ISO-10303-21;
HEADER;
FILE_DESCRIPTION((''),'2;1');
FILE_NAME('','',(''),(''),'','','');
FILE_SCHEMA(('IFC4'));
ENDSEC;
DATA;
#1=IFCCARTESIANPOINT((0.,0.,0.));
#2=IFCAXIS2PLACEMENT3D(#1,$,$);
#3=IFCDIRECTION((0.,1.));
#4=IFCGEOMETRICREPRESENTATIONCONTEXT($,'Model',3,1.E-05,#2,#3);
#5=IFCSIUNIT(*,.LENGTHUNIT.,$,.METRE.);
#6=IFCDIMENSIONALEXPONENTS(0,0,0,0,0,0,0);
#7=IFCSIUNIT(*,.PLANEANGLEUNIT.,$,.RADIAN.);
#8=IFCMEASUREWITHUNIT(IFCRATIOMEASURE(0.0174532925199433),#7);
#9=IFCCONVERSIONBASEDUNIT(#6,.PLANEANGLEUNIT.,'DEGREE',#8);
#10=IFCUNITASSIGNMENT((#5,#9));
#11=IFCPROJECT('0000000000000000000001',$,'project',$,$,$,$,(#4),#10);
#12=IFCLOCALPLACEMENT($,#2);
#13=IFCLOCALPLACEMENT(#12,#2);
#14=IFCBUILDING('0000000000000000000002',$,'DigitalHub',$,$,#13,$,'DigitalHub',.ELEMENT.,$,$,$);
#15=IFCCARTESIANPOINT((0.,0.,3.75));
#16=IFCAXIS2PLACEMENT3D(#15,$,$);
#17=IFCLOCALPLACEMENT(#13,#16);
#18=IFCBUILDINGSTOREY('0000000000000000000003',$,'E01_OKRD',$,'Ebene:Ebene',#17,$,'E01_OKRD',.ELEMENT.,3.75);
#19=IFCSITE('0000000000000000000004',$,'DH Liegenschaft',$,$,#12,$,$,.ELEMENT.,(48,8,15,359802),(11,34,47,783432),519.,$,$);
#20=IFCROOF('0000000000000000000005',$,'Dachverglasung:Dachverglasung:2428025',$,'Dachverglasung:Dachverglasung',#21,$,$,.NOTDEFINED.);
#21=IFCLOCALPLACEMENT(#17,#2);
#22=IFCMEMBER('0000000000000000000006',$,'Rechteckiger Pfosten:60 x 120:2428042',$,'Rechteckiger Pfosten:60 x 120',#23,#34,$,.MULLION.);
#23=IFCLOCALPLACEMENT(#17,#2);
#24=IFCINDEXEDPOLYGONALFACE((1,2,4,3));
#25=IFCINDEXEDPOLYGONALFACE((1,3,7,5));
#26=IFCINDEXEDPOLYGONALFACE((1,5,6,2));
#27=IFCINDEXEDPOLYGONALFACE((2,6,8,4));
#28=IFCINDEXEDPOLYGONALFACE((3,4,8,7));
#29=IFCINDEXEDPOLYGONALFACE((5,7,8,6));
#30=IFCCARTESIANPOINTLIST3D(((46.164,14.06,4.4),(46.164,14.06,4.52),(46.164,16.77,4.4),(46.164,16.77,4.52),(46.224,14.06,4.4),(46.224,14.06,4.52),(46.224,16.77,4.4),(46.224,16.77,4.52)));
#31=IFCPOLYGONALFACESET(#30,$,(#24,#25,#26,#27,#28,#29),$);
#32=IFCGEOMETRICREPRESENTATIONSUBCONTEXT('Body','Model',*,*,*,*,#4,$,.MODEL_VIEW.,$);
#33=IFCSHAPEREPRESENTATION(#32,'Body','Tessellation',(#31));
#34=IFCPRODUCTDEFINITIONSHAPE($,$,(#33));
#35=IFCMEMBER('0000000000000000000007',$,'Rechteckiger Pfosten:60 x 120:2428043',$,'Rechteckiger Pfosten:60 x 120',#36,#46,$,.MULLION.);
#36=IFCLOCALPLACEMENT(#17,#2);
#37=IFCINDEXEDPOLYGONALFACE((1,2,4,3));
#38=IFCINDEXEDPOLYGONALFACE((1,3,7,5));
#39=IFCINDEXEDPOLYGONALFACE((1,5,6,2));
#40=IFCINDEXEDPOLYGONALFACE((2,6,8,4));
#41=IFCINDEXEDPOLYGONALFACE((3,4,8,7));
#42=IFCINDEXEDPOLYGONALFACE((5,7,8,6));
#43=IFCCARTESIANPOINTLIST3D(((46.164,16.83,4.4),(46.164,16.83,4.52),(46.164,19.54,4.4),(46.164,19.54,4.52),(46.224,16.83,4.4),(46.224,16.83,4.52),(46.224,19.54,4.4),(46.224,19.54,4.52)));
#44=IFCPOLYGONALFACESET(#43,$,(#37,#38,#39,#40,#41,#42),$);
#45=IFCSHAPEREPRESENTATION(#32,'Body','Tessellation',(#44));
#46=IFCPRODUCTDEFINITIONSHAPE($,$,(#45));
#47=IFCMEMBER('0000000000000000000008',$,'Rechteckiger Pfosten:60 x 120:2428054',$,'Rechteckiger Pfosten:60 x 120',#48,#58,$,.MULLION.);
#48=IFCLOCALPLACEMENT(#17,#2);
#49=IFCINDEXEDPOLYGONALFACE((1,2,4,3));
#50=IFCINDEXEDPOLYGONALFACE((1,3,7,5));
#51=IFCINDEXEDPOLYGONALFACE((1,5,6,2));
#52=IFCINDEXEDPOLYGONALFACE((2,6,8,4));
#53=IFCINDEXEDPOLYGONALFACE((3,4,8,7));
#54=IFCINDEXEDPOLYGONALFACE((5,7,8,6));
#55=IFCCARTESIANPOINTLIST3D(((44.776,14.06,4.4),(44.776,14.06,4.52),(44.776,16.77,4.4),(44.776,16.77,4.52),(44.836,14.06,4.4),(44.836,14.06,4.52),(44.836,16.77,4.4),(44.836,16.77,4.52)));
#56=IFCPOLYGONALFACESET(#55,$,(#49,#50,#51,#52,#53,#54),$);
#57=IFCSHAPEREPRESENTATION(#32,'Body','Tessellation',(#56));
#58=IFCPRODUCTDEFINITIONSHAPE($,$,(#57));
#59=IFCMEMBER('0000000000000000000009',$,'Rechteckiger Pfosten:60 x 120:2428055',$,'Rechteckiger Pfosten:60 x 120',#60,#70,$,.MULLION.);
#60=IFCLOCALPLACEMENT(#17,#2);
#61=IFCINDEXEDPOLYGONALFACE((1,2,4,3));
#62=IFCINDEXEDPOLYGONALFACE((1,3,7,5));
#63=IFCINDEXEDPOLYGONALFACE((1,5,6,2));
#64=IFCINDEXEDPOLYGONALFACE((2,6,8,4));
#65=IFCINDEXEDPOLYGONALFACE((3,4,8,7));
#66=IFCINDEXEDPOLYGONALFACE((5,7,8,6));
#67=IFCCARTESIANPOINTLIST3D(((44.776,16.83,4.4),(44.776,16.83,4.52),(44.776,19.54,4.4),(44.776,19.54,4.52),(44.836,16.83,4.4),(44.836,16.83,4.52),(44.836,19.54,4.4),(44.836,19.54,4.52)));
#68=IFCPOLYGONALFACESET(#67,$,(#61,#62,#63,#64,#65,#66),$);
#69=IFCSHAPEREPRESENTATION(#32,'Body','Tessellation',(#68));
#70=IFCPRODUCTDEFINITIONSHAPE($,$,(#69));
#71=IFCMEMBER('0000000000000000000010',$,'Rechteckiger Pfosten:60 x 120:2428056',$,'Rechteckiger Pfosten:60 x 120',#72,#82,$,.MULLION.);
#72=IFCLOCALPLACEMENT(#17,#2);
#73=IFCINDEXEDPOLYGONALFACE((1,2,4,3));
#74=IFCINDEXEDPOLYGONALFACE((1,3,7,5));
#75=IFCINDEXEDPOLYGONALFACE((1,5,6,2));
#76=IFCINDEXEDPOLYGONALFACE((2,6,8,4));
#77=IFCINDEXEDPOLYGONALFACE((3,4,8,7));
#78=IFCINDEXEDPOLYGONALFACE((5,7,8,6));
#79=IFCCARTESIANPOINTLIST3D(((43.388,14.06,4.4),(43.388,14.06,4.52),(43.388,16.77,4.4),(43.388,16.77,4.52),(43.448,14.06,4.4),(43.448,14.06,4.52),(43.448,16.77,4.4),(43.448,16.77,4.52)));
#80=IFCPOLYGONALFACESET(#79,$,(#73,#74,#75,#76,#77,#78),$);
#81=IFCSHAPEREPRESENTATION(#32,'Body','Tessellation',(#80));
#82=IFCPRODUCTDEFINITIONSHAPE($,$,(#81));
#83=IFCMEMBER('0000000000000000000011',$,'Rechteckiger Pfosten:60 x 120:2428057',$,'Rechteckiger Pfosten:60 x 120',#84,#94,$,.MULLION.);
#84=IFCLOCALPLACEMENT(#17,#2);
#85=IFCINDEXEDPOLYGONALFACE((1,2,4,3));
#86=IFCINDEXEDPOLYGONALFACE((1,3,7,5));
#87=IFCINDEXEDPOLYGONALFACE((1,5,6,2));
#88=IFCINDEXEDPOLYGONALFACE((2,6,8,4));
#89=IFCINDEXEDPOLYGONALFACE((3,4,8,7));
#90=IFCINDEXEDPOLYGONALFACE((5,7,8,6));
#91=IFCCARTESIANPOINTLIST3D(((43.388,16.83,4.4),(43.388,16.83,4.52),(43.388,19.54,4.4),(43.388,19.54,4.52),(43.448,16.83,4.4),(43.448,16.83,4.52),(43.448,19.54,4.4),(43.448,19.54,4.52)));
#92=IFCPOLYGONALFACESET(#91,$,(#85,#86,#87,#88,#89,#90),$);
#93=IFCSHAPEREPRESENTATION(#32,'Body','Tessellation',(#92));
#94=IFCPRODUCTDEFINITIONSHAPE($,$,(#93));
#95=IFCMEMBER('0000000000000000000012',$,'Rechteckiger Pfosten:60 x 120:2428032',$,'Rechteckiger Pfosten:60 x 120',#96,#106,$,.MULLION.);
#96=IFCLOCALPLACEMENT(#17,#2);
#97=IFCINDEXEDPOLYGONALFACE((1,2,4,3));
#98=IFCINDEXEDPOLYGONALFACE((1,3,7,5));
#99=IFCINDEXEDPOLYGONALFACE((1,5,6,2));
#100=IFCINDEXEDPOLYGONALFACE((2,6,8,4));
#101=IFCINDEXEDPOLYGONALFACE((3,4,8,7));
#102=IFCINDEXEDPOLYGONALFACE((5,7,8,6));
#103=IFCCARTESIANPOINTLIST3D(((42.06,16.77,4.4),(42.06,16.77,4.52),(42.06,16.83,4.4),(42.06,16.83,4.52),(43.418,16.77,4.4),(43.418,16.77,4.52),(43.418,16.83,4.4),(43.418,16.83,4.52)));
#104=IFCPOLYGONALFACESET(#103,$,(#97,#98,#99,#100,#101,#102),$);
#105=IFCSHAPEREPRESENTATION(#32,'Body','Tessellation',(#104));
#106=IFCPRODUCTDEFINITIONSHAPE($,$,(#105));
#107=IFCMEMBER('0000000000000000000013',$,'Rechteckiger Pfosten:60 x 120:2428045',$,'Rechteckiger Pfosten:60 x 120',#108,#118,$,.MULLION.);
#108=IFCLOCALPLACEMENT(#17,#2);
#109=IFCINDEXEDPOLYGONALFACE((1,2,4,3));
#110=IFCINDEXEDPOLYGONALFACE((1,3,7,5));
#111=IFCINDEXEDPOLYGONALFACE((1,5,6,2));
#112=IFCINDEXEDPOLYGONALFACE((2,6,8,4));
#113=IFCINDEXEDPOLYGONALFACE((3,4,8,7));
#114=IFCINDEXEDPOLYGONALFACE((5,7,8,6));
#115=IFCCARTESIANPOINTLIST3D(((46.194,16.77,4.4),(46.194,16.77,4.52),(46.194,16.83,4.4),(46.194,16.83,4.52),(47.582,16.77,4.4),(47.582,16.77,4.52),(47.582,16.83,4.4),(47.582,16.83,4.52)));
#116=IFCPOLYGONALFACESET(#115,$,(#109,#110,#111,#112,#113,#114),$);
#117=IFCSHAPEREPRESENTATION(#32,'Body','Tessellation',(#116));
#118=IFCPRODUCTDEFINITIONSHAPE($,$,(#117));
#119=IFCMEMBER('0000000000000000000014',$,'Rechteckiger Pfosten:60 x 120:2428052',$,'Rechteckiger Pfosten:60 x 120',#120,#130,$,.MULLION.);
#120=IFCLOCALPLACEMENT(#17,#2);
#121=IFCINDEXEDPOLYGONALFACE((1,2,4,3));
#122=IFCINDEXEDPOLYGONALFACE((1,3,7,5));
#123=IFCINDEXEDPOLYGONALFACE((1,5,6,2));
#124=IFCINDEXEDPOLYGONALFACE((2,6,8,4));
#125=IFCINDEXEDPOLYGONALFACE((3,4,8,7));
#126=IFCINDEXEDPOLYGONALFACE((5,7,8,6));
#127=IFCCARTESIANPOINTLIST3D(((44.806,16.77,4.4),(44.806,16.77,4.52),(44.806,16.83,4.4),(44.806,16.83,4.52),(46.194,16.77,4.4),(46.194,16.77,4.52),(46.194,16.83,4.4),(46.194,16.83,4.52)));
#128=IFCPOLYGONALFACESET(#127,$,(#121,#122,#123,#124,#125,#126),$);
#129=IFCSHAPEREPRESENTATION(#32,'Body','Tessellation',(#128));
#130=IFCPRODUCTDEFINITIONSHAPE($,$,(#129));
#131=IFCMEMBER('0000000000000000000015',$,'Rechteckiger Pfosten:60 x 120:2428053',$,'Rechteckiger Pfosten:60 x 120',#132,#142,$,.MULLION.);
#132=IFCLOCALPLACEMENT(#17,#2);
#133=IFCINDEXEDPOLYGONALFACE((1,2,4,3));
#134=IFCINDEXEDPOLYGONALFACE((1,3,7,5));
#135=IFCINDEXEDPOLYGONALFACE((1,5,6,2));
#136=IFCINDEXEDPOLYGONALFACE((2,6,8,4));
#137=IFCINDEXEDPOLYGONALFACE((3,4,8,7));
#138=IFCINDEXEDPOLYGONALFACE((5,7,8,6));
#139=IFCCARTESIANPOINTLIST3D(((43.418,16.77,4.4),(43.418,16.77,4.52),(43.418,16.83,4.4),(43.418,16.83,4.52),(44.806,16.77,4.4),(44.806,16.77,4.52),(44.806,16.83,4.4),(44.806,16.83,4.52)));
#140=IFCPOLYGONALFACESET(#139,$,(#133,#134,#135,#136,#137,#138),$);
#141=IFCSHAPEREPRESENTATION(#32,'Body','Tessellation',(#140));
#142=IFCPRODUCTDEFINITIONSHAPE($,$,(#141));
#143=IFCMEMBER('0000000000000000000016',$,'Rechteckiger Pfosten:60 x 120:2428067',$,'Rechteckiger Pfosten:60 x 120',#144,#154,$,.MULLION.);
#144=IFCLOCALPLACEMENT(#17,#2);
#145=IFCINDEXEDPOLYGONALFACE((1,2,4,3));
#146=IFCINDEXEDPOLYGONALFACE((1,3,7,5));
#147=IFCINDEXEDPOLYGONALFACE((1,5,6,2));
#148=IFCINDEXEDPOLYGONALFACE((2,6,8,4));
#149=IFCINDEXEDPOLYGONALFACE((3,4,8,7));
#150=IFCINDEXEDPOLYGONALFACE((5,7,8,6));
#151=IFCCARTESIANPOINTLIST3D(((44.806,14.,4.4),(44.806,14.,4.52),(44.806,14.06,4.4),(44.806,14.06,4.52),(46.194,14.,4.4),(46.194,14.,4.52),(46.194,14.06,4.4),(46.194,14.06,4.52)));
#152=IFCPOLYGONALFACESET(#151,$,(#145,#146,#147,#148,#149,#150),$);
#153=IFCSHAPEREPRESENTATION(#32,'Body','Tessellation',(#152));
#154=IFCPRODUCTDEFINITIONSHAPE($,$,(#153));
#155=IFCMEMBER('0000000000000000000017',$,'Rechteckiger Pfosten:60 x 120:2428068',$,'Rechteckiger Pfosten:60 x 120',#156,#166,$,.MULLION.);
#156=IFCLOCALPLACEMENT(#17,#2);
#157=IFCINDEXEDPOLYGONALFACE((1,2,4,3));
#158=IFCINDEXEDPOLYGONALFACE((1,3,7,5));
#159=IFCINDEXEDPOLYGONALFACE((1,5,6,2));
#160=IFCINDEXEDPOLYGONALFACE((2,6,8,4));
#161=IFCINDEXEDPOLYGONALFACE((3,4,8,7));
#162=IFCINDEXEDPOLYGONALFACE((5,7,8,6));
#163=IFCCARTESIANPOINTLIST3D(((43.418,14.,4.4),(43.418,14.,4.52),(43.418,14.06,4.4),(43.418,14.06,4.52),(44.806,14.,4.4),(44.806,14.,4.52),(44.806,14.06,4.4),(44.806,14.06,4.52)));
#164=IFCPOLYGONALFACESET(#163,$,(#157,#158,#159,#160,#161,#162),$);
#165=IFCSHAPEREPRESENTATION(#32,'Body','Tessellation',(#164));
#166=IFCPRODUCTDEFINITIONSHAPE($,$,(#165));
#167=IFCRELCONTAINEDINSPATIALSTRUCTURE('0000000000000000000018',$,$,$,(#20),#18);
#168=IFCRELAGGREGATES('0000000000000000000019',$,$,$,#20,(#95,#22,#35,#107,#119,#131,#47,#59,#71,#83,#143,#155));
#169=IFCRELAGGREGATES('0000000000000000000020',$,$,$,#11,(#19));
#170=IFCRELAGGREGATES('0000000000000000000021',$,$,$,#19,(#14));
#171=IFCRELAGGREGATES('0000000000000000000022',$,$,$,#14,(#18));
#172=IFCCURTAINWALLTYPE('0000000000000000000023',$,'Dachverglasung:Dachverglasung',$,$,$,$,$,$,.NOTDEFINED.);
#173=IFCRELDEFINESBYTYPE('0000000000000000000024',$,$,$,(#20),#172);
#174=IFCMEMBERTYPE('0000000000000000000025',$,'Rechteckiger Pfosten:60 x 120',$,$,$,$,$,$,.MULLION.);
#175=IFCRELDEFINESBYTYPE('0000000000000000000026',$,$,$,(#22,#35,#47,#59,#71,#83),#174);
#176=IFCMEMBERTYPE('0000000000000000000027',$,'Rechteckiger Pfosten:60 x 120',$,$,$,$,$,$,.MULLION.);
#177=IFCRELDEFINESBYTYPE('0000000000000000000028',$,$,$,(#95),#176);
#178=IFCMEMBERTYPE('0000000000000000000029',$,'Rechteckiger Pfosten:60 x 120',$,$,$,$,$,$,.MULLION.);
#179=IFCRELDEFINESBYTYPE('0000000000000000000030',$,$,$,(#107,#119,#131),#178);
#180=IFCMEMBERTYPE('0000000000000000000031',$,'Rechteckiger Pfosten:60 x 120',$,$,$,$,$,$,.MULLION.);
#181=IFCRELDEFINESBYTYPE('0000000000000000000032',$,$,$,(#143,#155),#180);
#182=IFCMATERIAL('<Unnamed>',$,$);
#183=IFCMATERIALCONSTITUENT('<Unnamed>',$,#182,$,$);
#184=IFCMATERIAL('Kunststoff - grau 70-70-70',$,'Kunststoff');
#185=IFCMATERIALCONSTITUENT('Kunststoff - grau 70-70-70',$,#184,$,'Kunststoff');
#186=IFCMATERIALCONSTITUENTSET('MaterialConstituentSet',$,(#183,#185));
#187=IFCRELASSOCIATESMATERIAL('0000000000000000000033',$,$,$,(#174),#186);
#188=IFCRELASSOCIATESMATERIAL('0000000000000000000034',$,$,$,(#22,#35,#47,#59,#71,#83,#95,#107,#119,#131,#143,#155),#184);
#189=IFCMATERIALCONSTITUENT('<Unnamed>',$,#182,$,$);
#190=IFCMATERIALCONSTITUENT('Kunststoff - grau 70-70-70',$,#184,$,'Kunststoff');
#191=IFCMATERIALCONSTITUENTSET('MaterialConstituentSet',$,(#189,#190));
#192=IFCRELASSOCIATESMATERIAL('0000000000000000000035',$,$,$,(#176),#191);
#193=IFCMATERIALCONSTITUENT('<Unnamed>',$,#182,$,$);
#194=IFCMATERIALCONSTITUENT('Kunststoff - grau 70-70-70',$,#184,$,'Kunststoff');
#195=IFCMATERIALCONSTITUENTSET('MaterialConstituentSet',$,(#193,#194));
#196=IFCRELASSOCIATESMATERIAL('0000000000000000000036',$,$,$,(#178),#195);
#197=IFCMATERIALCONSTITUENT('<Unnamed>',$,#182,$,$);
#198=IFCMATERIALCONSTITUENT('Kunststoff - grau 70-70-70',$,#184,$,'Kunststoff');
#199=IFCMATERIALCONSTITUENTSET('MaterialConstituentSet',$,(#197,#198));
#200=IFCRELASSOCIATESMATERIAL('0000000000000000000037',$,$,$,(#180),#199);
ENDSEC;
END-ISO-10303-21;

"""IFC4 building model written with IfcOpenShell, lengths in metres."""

from ifc_helpers import new_model, entity, si_unit, converted_unit, direction, frame, origin, place, context, subcontext, project, spatial, indexed_curve, outline, extrude, source, transform, mapped, material, constituent, constituent_set, type_object, type_shapes, element, aggregate, save


model = new_model("IFC4")

# Units and contexts
model_context = context("Model", 3, precision=1e-05, world=origin(), true_north=direction((0.0, 1.0)))
body_context = subcontext(model_context, "Body", "Model", "MODEL_VIEW")
ifc_project = project(units=[si_unit("LENGTHUNIT", "METRE"), converted_unit("PLANEANGLEUNIT", "DEGREE", entity("IfcRatioMeasure", 0.0174532925199433), si_unit("PLANEANGLEUNIT", "RADIAN"), dimensions=[0, 0, 0, 0, 0, 0, 0])], contexts=[model_context])

# Site, building, storey
site_placement = place(None, frame((0.0, 0.0, 0.0)))
site = spatial("IfcSite", under=ifc_project, at=site_placement, Name="DH Liegenschaft", CompositionType="ELEMENT", RefLatitude=(48, 8, 15, 359802), RefLongitude=(11, 34, 47, 783432), RefElevation=519.0)
building_placement = place(site_placement, origin())
building = spatial("IfcBuilding", under=site, at=building_placement, Name="DigitalHub", LongName="DigitalHub", CompositionType="ELEMENT")
storey_placement = place(building_placement, frame((0.0, 0.0, 3.75)))
storey = spatial("IfcBuildingStorey", under=building, at=storey_placement, Name="E01_OKRD", ObjectType="Ebene:Ebene", LongName="E01_OKRD", CompositionType="ELEMENT", Elevation=3.75)

# Roof, members
curtain_wall_type = type_object("IfcCurtainWallType", Name="Dachverglasung:Dachverglasung", PredefinedType="NOTDEFINED")
roof_placement = place(storey_placement, frame((0.0, 0.0, -3.75)))
roof = element("IfcRoof", 1, at=roof_placement, inside=storey, type_object=curtain_wall_type, Name="Dachverglasung:Dachverglasung:2428025", ObjectType="Dachverglasung:Dachverglasung", PredefinedType="NOTDEFINED")
ifc_material_1 = material(Name="Kunststoff - grau 70-70-70", Category="Kunststoff")
ifc_material_2 = material(Name="<Unnamed>")
ifc_constituent_1 = constituent(ifc_material_2, Name="<Unnamed>")
ifc_constituent_2 = constituent(ifc_material_1, Name="Kunststoff - grau 70-70-70", Category="Kunststoff")
ifc_constituent_set_1 = constituent_set(constituents=[ifc_constituent_1, ifc_constituent_2], Name="MaterialConstituentSet")
member_type_1 = type_object("IfcMemberType", Name="Rechteckiger Pfosten:60 x 120", PredefinedType="MULLION", material=ifc_constituent_set_1)
shared_shape_1 = source(origin(), body_context, "Body", "SweptSolid", [
    extrude(outline(indexed_curve([(-0.06, -0.03), (0.06, -0.03), (0.06, 0.03), (-0.06, 0.03), (-0.06, -0.03)], self_intersect=False)), frame((0.0, 0.0, -2.71), z_axis=(0.0, 0.0, 1.0), x_axis=(0.0, -1.0, 0.0)), (0.0, 0.0, 1.0), 2.71),
])
type_shapes(member_type_1, [shared_shape_1])
member_1_placement = place(storey_placement, frame((46.194, 14.06, 4.46), z_axis=(0.0, -1.0, 0.0), x_axis=(-1.0, 0.0, 0.0)))
member_1 = element("IfcMember", 2, at=member_1_placement, type_object=member_type_1, material=ifc_material_1, Name="Rechteckiger Pfosten:60 x 120:2428042", ObjectType="Rechteckiger Pfosten:60 x 120", PredefinedType="MULLION", context=body_context, shape_type="MappedRepresentation", body=[
    mapped(shared_shape_1, transform((0.0, 0.0, 0.0), scale=1.0)),
])
member_2_placement = place(storey_placement, frame((46.194, 16.83, 4.46), z_axis=(0.0, -1.0, 0.0), x_axis=(-1.0, 0.0, 0.0)))
member_2 = element("IfcMember", 3, at=member_2_placement, type_object=member_type_1, material=ifc_material_1, Name="Rechteckiger Pfosten:60 x 120:2428043", ObjectType="Rechteckiger Pfosten:60 x 120", PredefinedType="MULLION", context=body_context, shape_type="MappedRepresentation", body=[
    mapped(shared_shape_1, transform((0.0, 0.0, 0.0), scale=1.0)),
])
member_3_placement = place(storey_placement, frame((44.806, 14.06, 4.46), z_axis=(0.0, -1.0, 0.0), x_axis=(-1.0, 0.0, 0.0)))
member_3 = element("IfcMember", 4, at=member_3_placement, type_object=member_type_1, material=ifc_material_1, Name="Rechteckiger Pfosten:60 x 120:2428054", ObjectType="Rechteckiger Pfosten:60 x 120", PredefinedType="MULLION", context=body_context, shape_type="MappedRepresentation", body=[
    mapped(shared_shape_1, transform((0.0, 0.0, 0.0), scale=1.0)),
])
member_4_placement = place(storey_placement, frame((44.806, 16.83, 4.46), z_axis=(0.0, -1.0, 0.0), x_axis=(-1.0, 0.0, 0.0)))
member_4 = element("IfcMember", 5, at=member_4_placement, type_object=member_type_1, material=ifc_material_1, Name="Rechteckiger Pfosten:60 x 120:2428055", ObjectType="Rechteckiger Pfosten:60 x 120", PredefinedType="MULLION", context=body_context, shape_type="MappedRepresentation", body=[
    mapped(shared_shape_1, transform((0.0, 0.0, 0.0), scale=1.0)),
])
member_5_placement = place(storey_placement, frame((43.418, 14.06, 4.46), z_axis=(0.0, -1.0, 0.0), x_axis=(-1.0, 0.0, 0.0)))
member_5 = element("IfcMember", 6, at=member_5_placement, type_object=member_type_1, material=ifc_material_1, Name="Rechteckiger Pfosten:60 x 120:2428056", ObjectType="Rechteckiger Pfosten:60 x 120", PredefinedType="MULLION", context=body_context, shape_type="MappedRepresentation", body=[
    mapped(shared_shape_1, transform((0.0, 0.0, 0.0), scale=1.0)),
])
member_6_placement = place(storey_placement, frame((43.418, 16.83, 4.46), z_axis=(0.0, -1.0, 0.0), x_axis=(-1.0, 0.0, 0.0)))
member_6 = element("IfcMember", 7, at=member_6_placement, type_object=member_type_1, material=ifc_material_1, Name="Rechteckiger Pfosten:60 x 120:2428057", ObjectType="Rechteckiger Pfosten:60 x 120", PredefinedType="MULLION", context=body_context, shape_type="MappedRepresentation", body=[
    mapped(shared_shape_1, transform((0.0, 0.0, 0.0), scale=1.0)),
])
ifc_constituent_3 = constituent(ifc_material_2, Name="<Unnamed>")
ifc_constituent_4 = constituent(ifc_material_1, Name="Kunststoff - grau 70-70-70", Category="Kunststoff")
ifc_constituent_set_2 = constituent_set(constituents=[ifc_constituent_3, ifc_constituent_4], Name="MaterialConstituentSet")
member_type_2 = type_object("IfcMemberType", Name="Rechteckiger Pfosten:60 x 120", PredefinedType="MULLION", material=ifc_constituent_set_2)
shared_shape_2 = source(origin(), body_context, "Body", "SweptSolid", [
    extrude(outline(indexed_curve([(-0.06, -0.03), (0.06, -0.03), (0.06, 0.03), (-0.06, 0.03), (-0.06, -0.03)], self_intersect=False)), frame((0.0, 0.0, -1.358), z_axis=(0.0, 0.0, 1.0), x_axis=(0.0, -1.0, 0.0)), (0.0, 0.0, 1.0), 1.358),
])
type_shapes(member_type_2, [shared_shape_2])
member_7_placement = place(storey_placement, frame((42.06, 16.8, 4.46), z_axis=(-1.0, 0.0, 0.0), x_axis=(0.0, 1.0, 0.0)))
member_7 = element("IfcMember", 8, at=member_7_placement, type_object=member_type_2, material=ifc_material_1, Name="Rechteckiger Pfosten:60 x 120:2428032", ObjectType="Rechteckiger Pfosten:60 x 120", PredefinedType="MULLION", context=body_context, shape_type="MappedRepresentation", body=[
    mapped(shared_shape_2, transform((0.0, 0.0, 0.0), scale=1.0)),
])
ifc_constituent_5 = constituent(ifc_material_2, Name="<Unnamed>")
ifc_constituent_6 = constituent(ifc_material_1, Name="Kunststoff - grau 70-70-70", Category="Kunststoff")
ifc_constituent_set_3 = constituent_set(constituents=[ifc_constituent_5, ifc_constituent_6], Name="MaterialConstituentSet")
member_type_3 = type_object("IfcMemberType", Name="Rechteckiger Pfosten:60 x 120", PredefinedType="MULLION", material=ifc_constituent_set_3)
shared_shape_3 = source(origin(), body_context, "Body", "SweptSolid", [
    extrude(outline(indexed_curve([(-0.06, -0.03), (0.06, -0.03), (0.06, 0.03), (-0.06, 0.03), (-0.06, -0.03)], self_intersect=False)), frame((0.0, 0.0, -1.388), z_axis=(0.0, 0.0, 1.0), x_axis=(0.0, -1.0, 0.0)), (0.0, 0.0, 1.0), 1.388),
])
type_shapes(member_type_3, [shared_shape_3])
member_8_placement = place(storey_placement, frame((46.194, 16.8, 4.46), z_axis=(-1.0, 0.0, 0.0), x_axis=(0.0, 1.0, 0.0)))
member_8 = element("IfcMember", 9, at=member_8_placement, type_object=member_type_3, material=ifc_material_1, Name="Rechteckiger Pfosten:60 x 120:2428045", ObjectType="Rechteckiger Pfosten:60 x 120", PredefinedType="MULLION", context=body_context, shape_type="MappedRepresentation", body=[
    mapped(shared_shape_3, transform((0.0, 0.0, 0.0), scale=1.0)),
])
member_9_placement = place(storey_placement, frame((44.806, 16.8, 4.46), z_axis=(-1.0, 0.0, 0.0), x_axis=(0.0, 1.0, 0.0)))
member_9 = element("IfcMember", 10, at=member_9_placement, type_object=member_type_3, material=ifc_material_1, Name="Rechteckiger Pfosten:60 x 120:2428052", ObjectType="Rechteckiger Pfosten:60 x 120", PredefinedType="MULLION", context=body_context, shape_type="MappedRepresentation", body=[
    mapped(shared_shape_3, transform((0.0, 0.0, 0.0), scale=1.0)),
])
member_10_placement = place(storey_placement, frame((43.418, 16.8, 4.46), z_axis=(-1.0, 0.0, 0.0), x_axis=(0.0, 1.0, 0.0)))
member_10 = element("IfcMember", 11, at=member_10_placement, type_object=member_type_3, material=ifc_material_1, Name="Rechteckiger Pfosten:60 x 120:2428053", ObjectType="Rechteckiger Pfosten:60 x 120", PredefinedType="MULLION", context=body_context, shape_type="MappedRepresentation", body=[
    mapped(shared_shape_3, transform((0.0, 0.0, 0.0), scale=1.0)),
])
ifc_constituent_7 = constituent(ifc_material_2, Name="<Unnamed>")
ifc_constituent_8 = constituent(ifc_material_1, Name="Kunststoff - grau 70-70-70", Category="Kunststoff")
ifc_constituent_set_4 = constituent_set(constituents=[ifc_constituent_7, ifc_constituent_8], Name="MaterialConstituentSet")
member_type_4 = type_object("IfcMemberType", Name="Rechteckiger Pfosten:60 x 120", PredefinedType="MULLION", material=ifc_constituent_set_4)
shared_shape_4 = source(origin(), body_context, "Body", "SweptSolid", [
    extrude(outline(indexed_curve([(-0.06, -0.03), (0.06, -0.03), (0.06, 0.03), (-0.06, 0.03), (-0.06, -0.03)], self_intersect=False)), frame((-0.03, 0.0, -1.388), z_axis=(0.0, 0.0, 1.0), x_axis=(0.0, -1.0, 0.0)), (0.0, 0.0, 1.0), 1.388),
])
type_shapes(member_type_4, [shared_shape_4])
member_11_placement = place(storey_placement, frame((46.194, 14.0, 4.46), z_axis=(1.0, 0.0, 0.0), x_axis=(0.0, -1.0, 0.0)))
member_11 = element("IfcMember", 12, at=member_11_placement, type_object=member_type_4, material=ifc_material_1, Name="Rechteckiger Pfosten:60 x 120:2428067", ObjectType="Rechteckiger Pfosten:60 x 120", PredefinedType="MULLION", context=body_context, shape_type="MappedRepresentation", body=[
    mapped(shared_shape_4, transform((0.0, 0.0, 0.0), scale=1.0)),
])
member_12_placement = place(storey_placement, frame((44.806, 14.0, 4.46), z_axis=(1.0, 0.0, 0.0), x_axis=(0.0, -1.0, 0.0)))
member_12 = element("IfcMember", 13, at=member_12_placement, type_object=member_type_4, material=ifc_material_1, Name="Rechteckiger Pfosten:60 x 120:2428068", ObjectType="Rechteckiger Pfosten:60 x 120", PredefinedType="MULLION", context=body_context, shape_type="MappedRepresentation", body=[
    mapped(shared_shape_4, transform((0.0, 0.0, 0.0), scale=1.0)),
])
aggregate(roof, [member_7, member_1, member_2, member_8, member_9, member_10, member_3, member_4, member_5, member_6, member_11, member_12])

save(model, "model.ifc")
